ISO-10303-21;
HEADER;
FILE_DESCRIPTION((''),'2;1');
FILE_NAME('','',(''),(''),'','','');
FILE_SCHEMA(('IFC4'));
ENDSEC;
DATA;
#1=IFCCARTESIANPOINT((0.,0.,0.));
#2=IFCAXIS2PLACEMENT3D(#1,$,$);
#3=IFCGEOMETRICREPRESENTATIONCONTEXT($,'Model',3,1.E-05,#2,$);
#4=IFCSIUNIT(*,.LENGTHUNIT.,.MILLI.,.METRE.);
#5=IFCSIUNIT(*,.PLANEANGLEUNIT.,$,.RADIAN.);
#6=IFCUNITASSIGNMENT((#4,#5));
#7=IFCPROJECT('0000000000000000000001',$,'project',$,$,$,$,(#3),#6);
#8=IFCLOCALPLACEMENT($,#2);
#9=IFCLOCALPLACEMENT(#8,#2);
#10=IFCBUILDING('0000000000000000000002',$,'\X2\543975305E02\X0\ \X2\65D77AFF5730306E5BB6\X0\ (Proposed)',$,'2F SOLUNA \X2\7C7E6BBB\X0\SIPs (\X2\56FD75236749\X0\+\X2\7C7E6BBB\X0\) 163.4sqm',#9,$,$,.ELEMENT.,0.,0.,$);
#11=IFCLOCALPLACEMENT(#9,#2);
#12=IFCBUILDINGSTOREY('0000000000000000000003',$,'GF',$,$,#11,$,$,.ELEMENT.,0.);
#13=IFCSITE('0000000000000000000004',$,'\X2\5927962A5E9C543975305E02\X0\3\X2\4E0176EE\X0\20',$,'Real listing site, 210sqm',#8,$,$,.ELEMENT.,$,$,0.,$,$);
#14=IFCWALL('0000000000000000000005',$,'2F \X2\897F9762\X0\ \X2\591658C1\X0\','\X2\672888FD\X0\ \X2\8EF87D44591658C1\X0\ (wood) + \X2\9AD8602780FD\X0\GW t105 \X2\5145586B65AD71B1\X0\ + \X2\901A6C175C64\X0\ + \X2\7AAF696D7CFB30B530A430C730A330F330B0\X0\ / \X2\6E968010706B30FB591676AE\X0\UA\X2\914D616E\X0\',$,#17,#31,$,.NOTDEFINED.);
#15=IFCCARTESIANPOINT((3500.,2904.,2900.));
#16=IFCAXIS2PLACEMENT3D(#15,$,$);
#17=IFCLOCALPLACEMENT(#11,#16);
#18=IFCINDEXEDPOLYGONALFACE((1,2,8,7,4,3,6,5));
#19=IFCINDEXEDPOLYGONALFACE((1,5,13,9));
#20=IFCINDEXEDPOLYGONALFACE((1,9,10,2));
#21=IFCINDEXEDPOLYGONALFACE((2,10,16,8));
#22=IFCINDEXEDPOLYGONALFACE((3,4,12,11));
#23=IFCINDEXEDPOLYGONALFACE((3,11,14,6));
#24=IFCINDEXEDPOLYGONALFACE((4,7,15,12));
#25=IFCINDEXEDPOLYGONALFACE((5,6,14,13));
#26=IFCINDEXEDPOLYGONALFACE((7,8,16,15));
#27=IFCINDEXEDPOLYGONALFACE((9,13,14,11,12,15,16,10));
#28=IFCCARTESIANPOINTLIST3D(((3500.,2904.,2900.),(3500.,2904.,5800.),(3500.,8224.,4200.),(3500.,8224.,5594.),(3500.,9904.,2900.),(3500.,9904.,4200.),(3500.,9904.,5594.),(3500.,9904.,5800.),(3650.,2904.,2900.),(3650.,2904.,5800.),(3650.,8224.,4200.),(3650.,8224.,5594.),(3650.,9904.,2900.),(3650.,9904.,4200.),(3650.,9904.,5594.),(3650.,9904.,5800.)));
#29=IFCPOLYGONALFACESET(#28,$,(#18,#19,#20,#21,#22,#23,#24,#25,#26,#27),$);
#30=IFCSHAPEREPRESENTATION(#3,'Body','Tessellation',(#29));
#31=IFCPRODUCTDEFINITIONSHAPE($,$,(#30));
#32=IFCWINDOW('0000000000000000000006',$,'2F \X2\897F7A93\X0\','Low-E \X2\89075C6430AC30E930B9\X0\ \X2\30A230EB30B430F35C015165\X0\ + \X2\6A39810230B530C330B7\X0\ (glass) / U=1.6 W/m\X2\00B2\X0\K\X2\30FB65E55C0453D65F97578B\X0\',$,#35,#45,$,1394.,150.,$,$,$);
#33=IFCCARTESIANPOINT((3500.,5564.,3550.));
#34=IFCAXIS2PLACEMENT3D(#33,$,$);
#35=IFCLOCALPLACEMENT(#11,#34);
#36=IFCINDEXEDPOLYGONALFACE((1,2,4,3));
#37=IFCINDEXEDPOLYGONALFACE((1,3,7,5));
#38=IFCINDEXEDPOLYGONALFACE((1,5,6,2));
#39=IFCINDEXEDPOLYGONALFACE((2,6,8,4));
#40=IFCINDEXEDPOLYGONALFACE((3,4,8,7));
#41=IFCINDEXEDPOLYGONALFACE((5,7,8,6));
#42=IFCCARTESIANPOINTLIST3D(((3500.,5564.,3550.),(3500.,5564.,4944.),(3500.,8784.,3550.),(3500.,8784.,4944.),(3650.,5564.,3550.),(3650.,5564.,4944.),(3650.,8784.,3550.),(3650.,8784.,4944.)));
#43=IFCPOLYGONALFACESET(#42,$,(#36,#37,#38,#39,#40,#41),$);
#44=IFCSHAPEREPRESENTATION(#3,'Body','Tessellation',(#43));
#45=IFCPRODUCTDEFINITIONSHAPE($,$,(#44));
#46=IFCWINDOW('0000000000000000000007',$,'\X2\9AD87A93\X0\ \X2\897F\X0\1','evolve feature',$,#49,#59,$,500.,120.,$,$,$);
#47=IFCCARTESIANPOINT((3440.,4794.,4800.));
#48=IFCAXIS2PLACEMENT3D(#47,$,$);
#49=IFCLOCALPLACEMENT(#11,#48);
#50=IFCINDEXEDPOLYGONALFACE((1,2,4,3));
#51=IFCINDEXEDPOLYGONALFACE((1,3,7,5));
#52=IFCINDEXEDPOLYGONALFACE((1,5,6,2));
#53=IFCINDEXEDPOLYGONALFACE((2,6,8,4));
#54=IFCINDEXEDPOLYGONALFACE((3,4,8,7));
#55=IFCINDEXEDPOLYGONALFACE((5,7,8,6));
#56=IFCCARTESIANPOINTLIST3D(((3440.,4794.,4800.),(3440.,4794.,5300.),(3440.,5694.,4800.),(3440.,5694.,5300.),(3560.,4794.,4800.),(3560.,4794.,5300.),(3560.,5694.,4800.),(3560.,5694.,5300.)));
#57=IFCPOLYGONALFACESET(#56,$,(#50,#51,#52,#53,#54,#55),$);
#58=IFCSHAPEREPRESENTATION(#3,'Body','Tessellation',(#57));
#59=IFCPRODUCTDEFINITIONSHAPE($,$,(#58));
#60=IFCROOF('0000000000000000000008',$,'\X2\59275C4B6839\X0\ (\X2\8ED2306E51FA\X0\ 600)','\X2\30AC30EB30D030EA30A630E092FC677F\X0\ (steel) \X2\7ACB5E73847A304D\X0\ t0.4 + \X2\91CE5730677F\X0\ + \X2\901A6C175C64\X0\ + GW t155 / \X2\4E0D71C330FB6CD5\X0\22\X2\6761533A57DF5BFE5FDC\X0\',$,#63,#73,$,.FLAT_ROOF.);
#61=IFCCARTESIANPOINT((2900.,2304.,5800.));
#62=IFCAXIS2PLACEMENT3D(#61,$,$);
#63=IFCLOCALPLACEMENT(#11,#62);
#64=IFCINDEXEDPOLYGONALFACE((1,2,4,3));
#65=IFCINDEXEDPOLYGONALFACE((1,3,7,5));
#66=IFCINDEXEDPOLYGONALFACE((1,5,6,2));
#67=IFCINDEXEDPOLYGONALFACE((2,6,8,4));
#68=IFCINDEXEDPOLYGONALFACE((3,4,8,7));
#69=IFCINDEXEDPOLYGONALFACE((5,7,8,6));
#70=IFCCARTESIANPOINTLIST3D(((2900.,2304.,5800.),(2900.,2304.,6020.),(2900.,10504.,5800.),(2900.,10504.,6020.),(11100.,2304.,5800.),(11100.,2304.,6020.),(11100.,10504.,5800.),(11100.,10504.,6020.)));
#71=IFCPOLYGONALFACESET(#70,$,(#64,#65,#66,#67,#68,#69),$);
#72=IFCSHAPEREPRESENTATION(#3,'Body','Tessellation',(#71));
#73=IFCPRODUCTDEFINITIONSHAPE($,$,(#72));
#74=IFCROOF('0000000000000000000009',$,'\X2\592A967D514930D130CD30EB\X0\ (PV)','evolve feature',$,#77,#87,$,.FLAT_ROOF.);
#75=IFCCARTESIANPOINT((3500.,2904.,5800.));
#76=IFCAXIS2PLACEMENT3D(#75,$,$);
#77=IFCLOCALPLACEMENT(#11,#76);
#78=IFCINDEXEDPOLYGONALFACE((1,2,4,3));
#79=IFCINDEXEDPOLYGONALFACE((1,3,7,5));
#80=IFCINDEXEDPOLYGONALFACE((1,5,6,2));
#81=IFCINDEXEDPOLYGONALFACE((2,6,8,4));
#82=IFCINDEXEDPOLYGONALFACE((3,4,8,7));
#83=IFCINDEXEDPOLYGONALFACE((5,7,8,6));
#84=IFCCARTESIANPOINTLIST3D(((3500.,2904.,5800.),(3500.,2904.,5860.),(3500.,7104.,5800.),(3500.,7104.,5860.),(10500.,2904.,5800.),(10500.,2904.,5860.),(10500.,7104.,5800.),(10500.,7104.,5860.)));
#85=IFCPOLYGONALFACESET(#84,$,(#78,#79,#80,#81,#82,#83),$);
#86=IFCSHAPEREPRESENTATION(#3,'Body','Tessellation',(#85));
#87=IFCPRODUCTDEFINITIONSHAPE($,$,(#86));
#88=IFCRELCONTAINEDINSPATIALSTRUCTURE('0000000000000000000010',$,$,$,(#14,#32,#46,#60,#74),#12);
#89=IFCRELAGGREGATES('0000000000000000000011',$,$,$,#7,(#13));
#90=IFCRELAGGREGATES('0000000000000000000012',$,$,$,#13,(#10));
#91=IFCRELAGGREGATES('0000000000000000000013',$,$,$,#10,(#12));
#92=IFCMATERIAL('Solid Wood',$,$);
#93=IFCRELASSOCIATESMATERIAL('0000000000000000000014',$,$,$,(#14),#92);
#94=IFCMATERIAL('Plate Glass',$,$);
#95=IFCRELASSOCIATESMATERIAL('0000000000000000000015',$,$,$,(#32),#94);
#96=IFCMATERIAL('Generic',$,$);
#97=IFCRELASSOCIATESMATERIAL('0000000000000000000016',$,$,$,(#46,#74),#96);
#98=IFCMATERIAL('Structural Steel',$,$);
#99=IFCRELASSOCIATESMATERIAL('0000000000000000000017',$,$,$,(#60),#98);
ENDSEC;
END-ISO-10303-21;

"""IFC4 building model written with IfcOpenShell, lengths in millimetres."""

from ifc_helpers import new_model, si_unit, frame, frame_2d, origin, place, context, project, spatial, rectangle, extrude, material, element, fill, save


model = new_model("IFC4")

# Units and contexts
model_context = context("Model", 3, precision=1e-05, world=origin())
ifc_project = project(units=[si_unit("LENGTHUNIT", "METRE", prefix="MILLI"), si_unit("PLANEANGLEUNIT", "RADIAN")], contexts=[model_context])

# Site, building, storey
site_placement = place(None, origin())
site = spatial("IfcSite", under=ifc_project, at=site_placement, Name="大阪府吹田市3丁目20", ObjectType="Real listing site, 210sqm", CompositionType="ELEMENT", RefElevation=0.0)
building_placement = place(site_placement, origin())
building = spatial("IfcBuilding", under=site, at=building_placement, Name="吹田市 旗竿地の家 (Proposed)", ObjectType="2F SOLUNA 籾殻SIPs (国産杉+籾殻) 163.4sqm", CompositionType="ELEMENT", ElevationOfRefHeight=0.0, ElevationOfTerrain=0.0)
storey_placement = place(building_placement, origin())
storey = spatial("IfcBuildingStorey", under=building, at=storey_placement, Name="GF", CompositionType="ELEMENT", Elevation=0.0)

# Shared definitions
ifc_material_1 = material(Name="Solid Wood")
ifc_material_2 = material(Name="Generic")

# Shared definitions
ifc_material_3 = material(Name="Plate Glass")

# Wall, openings, windows
wall_1_placement = place(storey_placement, frame((3500.0, 2904.0, 2900.0)))
wall_1 = element("IfcWall", 1, at=wall_1_placement, inside=storey, material=ifc_material_1, Name="2F 西面 外壁", Description="木製 軸組外壁 (wood) + 高性能GW t105 充填断熱 + 通気層 + 窯業系サイディング / 準耐火・外皮UA配慮", PredefinedType="NOTDEFINED", context=model_context, shape_type="SweptSolid", body=[
    extrude(rectangle(XDim=150.0, YDim=7000.0, at=frame_2d((75.0, 3500.0))), frame((3500.0, 2904.0, 2900.0)), (0.0, 0.0, 1.0), 2900.0),
])
opening_1_placement = place(storey_placement, frame((3500.0, 5564.0, 3550.0)))
opening_1 = element("IfcOpeningElement", 2, at=opening_1_placement, cuts=wall_1, PredefinedType="NOTDEFINED", context=model_context, shape_type="SweptSolid", body=[
    extrude(rectangle(XDim=150.0, YDim=3220.0, at=frame_2d((75.0, 1610.0))), frame((3500.0, 5564.0, 3550.0)), (0.0, 0.0, 1.0), 1394.0),
])
opening_2_placement = place(storey_placement, frame((3440.0, 4794.0, 4800.0)))
opening_2 = element("IfcOpeningElement", 3, at=opening_2_placement, cuts=wall_1, PredefinedType="NOTDEFINED", context=model_context, shape_type="SweptSolid", body=[
    extrude(rectangle(XDim=120.0, YDim=900.0, at=frame_2d((60.0, 450.0))), frame((3440.0, 4794.0, 4800.0)), (0.0, 0.0, 1.0), 500.0),
])
window_1_placement = place(storey_placement, frame((3500.0, 5564.0, 3550.0)))
window_1 = element("IfcWindow", 4, at=window_1_placement, inside=storey, material=ifc_material_3, Name="2F 西窓", Description="Low-E 複層ガラス アルゴン封入 + 樹脂サッシ (glass) / U=1.6 W/m²K・日射取得型", OverallHeight=1394.0, OverallWidth=150.0, context=model_context, shape_type="SweptSolid", body=[
    extrude(rectangle(XDim=150.0, YDim=3220.0, at=frame_2d((75.0, 1610.0))), frame((3500.0, 5564.0, 3550.0)), (0.0, 0.0, 1.0), 1394.0),
])
fill(opening_1, window_1)
window_2_placement = place(storey_placement, frame((3440.0, 4794.0, 4800.0)))
window_2 = element("IfcWindow", 5, at=window_2_placement, inside=storey, material=ifc_material_2, Name="高窓 西1", Description="evolve feature", OverallHeight=500.0, OverallWidth=120.0, context=model_context, shape_type="SweptSolid", body=[
    extrude(rectangle(XDim=120.0, YDim=900.0, at=frame_2d((60.0, 450.0))), frame((3440.0, 4794.0, 4800.0)), (0.0, 0.0, 1.0), 500.0),
])
fill(opening_2, window_2)

# Roofs
ifc_material_4 = material(Name="Structural Steel")
roof_1_placement = place(storey_placement, frame((2900.0, 2304.0, 5800.0)))
element("IfcRoof", 6, at=roof_1_placement, inside=storey, material=ifc_material_4, Name="大屋根 (軒の出 600)", Description="ガルバリウム鋼板 (steel) 立平葺き t0.4 + 野地板 + 通気層 + GW t155 / 不燃・法22条区域対応", PredefinedType="FLAT_ROOF", context=model_context, shape_type="SweptSolid", body=[
    extrude(rectangle(XDim=8200.0, YDim=8200.0, at=frame_2d((4100.0, 4100.0))), frame((2900.0, 2304.0, 5800.0)), (0.0, 0.0, 1.0), 220.0),
])
roof_2_placement = place(storey_placement, frame((3500.0, 2904.0, 5800.0)))
element("IfcRoof", 7, at=roof_2_placement, inside=storey, material=ifc_material_2, Name="太陽光パネル (PV)", Description="evolve feature", PredefinedType="FLAT_ROOF", context=model_context, shape_type="SweptSolid", body=[
    extrude(rectangle(XDim=7000.0, YDim=4200.0, at=frame_2d((3500.0, 2100.0))), frame((3500.0, 2904.0, 5800.0)), (0.0, 0.0, 1.0), 60.0),
])

save(model, "model.ifc")
